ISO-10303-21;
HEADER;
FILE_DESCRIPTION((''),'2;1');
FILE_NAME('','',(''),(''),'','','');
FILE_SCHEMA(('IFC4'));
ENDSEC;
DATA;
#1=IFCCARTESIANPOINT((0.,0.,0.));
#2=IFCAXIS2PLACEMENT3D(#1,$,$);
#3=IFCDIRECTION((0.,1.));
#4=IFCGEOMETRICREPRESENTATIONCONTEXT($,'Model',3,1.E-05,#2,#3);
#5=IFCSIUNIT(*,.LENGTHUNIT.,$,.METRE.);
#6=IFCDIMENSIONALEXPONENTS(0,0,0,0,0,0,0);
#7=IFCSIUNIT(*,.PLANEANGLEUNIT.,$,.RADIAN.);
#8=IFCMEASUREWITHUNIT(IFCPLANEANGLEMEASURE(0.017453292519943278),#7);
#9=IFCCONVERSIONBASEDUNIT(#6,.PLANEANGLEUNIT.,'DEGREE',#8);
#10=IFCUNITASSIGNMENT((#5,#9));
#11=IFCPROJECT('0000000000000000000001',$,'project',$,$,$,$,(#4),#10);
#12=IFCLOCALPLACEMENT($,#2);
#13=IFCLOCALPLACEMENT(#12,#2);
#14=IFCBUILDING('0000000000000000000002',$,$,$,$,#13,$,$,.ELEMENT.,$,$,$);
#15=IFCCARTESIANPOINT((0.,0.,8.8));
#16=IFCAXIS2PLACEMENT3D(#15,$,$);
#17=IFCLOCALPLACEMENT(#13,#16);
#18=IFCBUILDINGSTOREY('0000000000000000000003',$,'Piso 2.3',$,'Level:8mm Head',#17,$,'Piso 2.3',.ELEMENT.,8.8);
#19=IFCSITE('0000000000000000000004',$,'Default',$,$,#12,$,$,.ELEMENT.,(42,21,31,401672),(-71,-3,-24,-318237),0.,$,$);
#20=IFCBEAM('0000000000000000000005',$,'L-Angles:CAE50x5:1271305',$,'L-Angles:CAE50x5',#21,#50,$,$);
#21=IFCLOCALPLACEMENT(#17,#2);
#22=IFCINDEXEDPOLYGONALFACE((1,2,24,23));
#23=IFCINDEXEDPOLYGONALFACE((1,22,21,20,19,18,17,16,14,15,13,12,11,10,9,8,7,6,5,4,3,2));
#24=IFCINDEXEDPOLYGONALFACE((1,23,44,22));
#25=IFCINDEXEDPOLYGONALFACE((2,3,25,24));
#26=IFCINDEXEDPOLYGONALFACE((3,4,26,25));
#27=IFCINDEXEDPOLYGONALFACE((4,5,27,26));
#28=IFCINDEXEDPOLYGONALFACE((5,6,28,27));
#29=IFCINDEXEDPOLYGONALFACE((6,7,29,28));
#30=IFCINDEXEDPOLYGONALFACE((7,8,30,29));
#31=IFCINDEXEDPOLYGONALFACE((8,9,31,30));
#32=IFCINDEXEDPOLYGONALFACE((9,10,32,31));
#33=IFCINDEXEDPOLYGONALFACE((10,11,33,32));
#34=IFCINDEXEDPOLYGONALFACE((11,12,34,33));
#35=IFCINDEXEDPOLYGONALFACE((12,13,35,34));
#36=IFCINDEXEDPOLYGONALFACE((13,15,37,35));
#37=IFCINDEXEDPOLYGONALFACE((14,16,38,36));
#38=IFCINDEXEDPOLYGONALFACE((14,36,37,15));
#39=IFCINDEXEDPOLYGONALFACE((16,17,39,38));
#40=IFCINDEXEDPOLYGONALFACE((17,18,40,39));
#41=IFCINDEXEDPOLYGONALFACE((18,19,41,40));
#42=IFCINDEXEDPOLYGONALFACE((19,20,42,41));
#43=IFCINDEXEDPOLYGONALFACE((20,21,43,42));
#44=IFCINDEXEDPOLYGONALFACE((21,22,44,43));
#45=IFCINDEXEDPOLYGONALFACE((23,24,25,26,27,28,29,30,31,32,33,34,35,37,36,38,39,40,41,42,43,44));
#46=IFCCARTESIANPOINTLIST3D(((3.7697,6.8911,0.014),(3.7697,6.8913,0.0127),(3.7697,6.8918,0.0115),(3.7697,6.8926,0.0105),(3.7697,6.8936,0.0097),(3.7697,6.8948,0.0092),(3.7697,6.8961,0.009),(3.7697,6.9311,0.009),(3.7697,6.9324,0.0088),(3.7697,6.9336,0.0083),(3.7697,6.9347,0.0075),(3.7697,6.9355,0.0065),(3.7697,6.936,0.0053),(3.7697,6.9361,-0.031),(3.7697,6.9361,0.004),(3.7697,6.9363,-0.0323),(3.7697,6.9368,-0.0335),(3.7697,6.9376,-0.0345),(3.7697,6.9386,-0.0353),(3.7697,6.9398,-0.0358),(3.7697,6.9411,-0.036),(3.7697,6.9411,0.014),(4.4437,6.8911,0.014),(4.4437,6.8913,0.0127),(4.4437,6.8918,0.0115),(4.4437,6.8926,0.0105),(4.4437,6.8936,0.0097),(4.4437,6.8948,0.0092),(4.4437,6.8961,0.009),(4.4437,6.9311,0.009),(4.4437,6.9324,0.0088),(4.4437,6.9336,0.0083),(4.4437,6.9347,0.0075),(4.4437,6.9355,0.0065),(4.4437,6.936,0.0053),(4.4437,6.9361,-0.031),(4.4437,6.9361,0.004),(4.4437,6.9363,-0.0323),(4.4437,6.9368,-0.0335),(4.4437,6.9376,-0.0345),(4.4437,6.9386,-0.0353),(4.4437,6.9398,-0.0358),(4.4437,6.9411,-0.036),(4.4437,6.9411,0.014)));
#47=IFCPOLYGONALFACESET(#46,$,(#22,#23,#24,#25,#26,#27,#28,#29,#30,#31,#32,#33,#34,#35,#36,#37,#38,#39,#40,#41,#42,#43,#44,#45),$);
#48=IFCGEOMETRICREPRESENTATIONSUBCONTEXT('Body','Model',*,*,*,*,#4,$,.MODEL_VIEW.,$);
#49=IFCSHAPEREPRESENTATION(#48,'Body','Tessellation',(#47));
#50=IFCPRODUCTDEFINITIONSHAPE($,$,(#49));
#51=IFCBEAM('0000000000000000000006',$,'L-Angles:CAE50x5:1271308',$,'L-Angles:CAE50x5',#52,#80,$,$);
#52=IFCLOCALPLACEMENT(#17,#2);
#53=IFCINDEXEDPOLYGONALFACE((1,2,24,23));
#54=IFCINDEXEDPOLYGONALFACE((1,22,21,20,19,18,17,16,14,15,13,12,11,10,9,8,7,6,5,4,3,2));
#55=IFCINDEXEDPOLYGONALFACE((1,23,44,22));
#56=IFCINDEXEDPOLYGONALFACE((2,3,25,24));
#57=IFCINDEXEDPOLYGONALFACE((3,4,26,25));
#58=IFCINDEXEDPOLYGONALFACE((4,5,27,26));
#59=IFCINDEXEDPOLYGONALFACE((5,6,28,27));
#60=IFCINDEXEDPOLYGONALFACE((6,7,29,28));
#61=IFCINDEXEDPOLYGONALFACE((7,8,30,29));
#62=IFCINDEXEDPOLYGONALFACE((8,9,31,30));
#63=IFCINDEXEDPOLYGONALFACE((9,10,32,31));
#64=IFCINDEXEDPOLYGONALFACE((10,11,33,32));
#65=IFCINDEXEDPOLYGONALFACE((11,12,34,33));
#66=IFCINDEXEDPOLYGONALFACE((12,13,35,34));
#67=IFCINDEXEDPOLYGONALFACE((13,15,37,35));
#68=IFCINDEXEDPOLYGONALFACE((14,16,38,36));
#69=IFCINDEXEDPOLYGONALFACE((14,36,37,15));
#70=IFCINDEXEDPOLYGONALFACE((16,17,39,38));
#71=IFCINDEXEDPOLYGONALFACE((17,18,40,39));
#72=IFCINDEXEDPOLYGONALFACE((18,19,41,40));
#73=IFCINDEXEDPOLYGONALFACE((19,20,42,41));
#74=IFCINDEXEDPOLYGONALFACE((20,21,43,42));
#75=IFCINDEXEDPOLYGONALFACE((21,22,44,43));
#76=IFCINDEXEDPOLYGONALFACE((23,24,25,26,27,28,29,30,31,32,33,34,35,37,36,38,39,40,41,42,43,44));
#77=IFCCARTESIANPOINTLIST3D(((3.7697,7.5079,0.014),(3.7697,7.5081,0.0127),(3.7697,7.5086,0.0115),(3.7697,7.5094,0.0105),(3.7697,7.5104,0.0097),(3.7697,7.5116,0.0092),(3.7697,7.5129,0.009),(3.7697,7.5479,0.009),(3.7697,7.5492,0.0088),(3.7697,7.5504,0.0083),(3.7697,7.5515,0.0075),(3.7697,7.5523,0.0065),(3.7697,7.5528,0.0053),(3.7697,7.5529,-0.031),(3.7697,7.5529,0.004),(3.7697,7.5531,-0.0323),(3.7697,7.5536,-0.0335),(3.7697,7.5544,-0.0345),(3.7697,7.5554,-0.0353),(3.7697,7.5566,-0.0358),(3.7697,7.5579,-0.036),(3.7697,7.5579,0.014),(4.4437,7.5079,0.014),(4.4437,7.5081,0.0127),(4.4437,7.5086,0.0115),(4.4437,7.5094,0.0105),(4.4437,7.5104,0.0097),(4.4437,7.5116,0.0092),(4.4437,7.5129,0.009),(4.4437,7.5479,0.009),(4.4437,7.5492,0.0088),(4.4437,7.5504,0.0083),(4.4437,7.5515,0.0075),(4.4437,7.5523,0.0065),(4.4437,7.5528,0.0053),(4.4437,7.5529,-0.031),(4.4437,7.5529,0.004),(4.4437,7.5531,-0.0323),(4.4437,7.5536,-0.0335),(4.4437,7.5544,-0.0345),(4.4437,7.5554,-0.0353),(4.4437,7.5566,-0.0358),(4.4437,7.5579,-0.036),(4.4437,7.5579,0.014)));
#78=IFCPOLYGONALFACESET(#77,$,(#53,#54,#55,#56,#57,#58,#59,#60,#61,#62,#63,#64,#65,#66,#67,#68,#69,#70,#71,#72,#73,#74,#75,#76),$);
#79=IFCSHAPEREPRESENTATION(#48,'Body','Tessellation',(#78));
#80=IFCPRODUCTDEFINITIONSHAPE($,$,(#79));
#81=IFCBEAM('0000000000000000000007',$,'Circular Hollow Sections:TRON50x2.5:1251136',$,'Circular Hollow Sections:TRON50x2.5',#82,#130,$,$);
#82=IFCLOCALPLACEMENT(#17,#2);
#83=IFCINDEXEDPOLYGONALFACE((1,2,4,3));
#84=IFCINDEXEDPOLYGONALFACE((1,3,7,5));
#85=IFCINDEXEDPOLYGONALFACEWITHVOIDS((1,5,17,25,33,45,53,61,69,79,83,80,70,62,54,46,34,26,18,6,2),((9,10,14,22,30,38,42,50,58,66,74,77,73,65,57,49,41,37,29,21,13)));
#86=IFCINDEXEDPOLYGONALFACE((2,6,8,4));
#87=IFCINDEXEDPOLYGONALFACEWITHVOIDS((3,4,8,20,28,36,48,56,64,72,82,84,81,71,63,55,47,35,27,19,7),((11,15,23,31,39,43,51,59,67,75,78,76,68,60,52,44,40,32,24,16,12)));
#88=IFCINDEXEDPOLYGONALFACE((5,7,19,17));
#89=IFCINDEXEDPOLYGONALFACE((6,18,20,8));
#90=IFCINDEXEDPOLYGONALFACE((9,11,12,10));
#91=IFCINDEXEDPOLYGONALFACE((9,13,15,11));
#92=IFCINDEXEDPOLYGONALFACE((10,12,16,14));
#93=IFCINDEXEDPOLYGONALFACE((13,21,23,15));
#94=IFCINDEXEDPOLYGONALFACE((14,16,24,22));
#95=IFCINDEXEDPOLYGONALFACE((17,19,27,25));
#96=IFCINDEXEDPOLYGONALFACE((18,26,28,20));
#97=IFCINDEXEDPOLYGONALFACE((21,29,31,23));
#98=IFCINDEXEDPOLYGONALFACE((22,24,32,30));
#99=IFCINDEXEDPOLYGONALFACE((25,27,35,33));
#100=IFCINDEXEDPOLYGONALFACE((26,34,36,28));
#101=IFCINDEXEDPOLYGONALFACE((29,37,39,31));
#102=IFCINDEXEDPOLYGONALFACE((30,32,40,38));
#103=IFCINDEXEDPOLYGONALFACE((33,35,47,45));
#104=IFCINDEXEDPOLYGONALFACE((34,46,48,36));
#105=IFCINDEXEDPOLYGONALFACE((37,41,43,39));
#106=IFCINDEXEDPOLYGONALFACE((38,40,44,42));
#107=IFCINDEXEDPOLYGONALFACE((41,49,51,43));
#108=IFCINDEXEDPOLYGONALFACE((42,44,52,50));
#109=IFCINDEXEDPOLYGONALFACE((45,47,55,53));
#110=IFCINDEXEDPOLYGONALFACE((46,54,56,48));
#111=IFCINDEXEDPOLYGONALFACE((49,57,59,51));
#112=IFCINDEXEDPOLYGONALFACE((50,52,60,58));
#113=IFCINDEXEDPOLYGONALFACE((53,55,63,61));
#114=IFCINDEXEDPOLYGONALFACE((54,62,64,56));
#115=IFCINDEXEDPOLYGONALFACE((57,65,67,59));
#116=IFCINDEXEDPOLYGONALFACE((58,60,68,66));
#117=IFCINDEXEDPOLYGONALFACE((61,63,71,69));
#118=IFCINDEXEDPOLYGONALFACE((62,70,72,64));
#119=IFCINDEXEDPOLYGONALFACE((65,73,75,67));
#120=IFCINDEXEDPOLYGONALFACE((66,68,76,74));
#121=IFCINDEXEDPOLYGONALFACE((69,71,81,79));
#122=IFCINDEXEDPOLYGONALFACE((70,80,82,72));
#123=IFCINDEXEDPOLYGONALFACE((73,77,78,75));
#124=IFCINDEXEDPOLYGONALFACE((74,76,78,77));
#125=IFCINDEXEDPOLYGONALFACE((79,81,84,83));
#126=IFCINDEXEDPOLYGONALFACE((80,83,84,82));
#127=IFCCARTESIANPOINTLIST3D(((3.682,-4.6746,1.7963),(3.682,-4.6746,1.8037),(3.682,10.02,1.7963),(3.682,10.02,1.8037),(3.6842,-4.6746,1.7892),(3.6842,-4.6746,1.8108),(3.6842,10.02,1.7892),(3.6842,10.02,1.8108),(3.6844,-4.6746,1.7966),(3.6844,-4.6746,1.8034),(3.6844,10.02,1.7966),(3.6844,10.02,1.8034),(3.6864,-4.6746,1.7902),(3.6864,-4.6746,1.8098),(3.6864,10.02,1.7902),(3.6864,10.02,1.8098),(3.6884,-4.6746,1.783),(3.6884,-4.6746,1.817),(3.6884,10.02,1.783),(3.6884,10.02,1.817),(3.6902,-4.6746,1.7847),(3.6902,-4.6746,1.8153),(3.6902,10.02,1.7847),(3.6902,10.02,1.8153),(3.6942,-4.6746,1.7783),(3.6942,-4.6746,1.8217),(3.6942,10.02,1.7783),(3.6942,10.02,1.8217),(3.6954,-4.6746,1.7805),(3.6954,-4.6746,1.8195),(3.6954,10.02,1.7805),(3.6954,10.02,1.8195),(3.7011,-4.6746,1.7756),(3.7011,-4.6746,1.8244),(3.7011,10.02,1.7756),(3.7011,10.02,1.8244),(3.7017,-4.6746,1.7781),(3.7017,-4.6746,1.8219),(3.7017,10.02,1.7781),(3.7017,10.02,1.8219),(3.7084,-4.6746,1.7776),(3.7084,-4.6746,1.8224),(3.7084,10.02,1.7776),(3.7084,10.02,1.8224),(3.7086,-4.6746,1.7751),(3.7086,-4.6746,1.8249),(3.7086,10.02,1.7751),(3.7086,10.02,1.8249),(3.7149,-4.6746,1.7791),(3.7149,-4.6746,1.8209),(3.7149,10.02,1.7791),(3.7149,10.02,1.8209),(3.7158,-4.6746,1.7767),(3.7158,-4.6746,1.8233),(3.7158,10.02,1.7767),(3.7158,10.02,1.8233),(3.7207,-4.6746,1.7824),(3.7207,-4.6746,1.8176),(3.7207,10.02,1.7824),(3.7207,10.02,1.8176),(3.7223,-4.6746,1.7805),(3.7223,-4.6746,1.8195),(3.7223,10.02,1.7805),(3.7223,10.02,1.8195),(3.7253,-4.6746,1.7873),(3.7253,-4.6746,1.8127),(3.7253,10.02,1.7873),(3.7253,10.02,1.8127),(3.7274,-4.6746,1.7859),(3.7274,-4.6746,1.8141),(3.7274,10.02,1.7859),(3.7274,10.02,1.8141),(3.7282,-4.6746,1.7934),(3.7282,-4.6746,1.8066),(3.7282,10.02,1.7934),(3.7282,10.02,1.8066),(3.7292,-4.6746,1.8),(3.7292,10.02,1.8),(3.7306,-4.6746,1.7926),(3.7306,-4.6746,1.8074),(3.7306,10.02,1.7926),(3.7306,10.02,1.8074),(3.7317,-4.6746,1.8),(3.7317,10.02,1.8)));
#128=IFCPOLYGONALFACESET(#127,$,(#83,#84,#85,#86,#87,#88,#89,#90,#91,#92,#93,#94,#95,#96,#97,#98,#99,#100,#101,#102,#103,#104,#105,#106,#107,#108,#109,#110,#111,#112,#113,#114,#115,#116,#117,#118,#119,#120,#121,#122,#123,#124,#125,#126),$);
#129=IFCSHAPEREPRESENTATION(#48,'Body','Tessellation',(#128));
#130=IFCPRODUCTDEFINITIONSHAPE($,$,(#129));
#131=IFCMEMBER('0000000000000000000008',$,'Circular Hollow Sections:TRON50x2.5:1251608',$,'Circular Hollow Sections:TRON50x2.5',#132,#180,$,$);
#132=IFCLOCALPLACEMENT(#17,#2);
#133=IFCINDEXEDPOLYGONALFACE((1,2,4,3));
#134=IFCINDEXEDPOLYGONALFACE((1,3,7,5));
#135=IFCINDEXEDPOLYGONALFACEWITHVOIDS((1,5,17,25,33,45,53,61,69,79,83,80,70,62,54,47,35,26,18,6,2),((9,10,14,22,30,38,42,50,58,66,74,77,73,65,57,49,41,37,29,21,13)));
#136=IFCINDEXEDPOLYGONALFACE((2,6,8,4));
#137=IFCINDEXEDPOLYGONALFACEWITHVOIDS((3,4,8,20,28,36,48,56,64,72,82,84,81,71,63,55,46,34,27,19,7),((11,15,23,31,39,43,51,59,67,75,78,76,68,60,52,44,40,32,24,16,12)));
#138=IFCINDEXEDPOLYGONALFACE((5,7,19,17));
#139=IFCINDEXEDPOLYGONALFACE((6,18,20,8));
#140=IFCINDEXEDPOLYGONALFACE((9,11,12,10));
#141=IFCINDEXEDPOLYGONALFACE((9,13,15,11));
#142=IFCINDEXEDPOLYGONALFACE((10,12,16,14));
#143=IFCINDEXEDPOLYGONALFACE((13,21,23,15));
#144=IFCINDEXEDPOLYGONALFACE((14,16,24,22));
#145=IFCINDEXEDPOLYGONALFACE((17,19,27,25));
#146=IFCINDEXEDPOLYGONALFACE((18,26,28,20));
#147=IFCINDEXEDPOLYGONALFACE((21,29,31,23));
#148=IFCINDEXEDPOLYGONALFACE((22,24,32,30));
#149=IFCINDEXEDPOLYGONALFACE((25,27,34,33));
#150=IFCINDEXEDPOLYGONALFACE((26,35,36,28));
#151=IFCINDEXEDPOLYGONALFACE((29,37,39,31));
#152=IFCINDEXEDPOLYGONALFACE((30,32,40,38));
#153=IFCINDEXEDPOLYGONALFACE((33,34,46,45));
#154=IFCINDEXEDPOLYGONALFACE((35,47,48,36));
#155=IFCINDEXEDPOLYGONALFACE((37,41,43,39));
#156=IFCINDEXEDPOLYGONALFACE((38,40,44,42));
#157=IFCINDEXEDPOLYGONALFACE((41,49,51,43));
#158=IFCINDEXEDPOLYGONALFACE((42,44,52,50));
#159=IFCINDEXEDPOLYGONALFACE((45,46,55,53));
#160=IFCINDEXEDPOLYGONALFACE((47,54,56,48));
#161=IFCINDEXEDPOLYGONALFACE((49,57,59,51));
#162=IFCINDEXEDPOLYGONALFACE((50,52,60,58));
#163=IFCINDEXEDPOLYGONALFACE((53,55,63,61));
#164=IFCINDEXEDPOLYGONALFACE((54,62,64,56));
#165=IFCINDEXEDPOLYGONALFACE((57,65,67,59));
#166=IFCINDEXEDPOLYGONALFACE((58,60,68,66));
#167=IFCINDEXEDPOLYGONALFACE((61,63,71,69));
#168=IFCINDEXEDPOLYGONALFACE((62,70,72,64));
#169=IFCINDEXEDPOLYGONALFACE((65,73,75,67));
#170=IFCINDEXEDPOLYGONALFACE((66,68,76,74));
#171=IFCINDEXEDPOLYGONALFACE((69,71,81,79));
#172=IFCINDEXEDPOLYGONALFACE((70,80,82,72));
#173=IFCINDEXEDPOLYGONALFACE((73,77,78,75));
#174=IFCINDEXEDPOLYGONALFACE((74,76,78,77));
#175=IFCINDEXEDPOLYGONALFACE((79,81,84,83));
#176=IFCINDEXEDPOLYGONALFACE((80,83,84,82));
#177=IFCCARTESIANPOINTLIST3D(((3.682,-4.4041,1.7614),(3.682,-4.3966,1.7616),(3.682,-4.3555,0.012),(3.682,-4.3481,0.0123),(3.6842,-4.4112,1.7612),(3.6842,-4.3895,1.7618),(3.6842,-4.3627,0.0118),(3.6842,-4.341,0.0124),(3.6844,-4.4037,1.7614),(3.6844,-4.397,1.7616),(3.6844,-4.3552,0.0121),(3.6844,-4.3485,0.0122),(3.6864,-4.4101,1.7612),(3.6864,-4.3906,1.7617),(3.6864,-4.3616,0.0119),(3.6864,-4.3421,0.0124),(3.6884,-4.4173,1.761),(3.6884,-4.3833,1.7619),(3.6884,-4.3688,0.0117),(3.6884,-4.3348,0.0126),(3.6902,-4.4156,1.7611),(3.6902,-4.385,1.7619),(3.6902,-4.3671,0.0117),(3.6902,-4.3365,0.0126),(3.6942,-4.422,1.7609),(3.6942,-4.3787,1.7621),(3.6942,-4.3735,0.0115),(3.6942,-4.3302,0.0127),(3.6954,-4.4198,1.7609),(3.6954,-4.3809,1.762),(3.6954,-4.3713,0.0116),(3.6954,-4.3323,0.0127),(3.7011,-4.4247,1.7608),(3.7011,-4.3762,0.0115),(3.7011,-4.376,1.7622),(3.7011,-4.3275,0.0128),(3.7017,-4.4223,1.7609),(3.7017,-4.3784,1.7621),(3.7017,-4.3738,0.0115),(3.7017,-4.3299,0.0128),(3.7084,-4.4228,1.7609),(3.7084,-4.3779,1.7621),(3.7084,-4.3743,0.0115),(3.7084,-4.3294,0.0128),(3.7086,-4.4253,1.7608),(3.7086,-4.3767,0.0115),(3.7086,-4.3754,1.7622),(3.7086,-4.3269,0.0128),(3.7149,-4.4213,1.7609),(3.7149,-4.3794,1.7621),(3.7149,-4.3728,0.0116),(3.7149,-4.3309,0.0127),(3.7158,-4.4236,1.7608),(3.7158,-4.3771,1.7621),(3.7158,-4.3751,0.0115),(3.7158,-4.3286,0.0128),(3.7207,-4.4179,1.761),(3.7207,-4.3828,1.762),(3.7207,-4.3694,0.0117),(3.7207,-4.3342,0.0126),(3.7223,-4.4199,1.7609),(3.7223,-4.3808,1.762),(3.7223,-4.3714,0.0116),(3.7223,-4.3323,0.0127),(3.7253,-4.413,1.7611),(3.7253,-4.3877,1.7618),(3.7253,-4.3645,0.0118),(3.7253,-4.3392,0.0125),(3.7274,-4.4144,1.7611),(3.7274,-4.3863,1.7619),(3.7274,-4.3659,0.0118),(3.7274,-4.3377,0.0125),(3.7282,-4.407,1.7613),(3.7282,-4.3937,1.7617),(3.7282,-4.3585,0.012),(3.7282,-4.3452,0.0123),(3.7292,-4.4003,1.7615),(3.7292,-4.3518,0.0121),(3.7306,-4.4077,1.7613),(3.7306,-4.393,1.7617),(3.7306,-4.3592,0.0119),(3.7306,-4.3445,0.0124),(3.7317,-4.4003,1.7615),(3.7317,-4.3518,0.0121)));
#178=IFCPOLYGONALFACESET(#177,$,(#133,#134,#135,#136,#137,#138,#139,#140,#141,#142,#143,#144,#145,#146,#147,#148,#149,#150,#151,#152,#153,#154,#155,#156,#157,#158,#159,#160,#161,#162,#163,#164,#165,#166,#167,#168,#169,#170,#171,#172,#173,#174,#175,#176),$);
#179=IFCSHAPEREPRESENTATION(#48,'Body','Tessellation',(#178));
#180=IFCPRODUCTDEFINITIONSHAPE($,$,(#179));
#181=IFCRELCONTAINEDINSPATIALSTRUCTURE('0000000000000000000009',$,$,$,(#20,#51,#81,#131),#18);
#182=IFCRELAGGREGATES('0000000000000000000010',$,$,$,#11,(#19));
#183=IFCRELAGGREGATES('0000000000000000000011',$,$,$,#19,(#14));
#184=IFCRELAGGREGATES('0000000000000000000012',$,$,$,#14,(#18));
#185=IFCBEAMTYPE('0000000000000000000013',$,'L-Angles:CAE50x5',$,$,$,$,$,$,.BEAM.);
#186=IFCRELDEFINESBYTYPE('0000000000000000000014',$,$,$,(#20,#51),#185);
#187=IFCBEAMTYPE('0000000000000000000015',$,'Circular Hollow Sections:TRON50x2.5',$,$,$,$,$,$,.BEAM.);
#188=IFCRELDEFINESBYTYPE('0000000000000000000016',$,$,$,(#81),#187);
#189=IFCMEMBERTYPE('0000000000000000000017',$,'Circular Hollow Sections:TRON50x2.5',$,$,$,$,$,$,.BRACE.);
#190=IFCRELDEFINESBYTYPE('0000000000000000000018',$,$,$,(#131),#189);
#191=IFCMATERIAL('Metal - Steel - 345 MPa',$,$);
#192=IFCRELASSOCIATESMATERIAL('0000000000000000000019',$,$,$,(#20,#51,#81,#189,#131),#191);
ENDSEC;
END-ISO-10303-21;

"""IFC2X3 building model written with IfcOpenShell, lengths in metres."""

from ifc_helpers import new_model, entity, si_unit, converted_unit, direction, frame, frame_2d, origin, origin_2d_with_axis, place, context, subcontext, project, spatial, polyline, circle_curve, parameter, trimmed, segment, composite_curve, hollow_circle, outline, extrude, source, transform, mapped, material, type_object, type_shapes, element, save


model = new_model("IFC2X3")

# Units and contexts
model_context = context("Model", 3, precision=1e-05, world=origin(), true_north=direction((0.0, 1.0)))
body_context = subcontext(model_context, "Body", "Model", "MODEL_VIEW")
ifc_project = project(units=[si_unit("LENGTHUNIT", "METRE"), converted_unit("PLANEANGLEUNIT", "DEGREE", entity("IfcPlaneAngleMeasure", 0.017453292519943278), si_unit("PLANEANGLEUNIT", "RADIAN"), dimensions=[0, 0, 0, 0, 0, 0, 0])], contexts=[model_context])

# Site, building, storey
site_placement = place(None, origin())
site = spatial("IfcSite", under=ifc_project, at=site_placement, Name="Default", CompositionType="ELEMENT", RefLatitude=(42, 21, 31, 401672), RefLongitude=(-71, -3, -24, -318237), RefElevation=0.0)
building_placement = place(site_placement, origin())
building = spatial("IfcBuilding", under=site, at=building_placement, CompositionType="ELEMENT")
storey_placement = place(building_placement, frame((0.0, 0.0, 8.8)))
storey = spatial("IfcBuildingStorey", under=building, at=storey_placement, Name="Piso 2.3", ObjectType="Level:8mm Head", LongName="Piso 2.3", CompositionType="ELEMENT", Elevation=8.8)

# Beams
ifc_material_1 = material(Name="Metal - Steel - 345 MPa")
beam_type_1 = type_object("IfcBeamType", Name="L-Angles:CAE50x5", PredefinedType="BEAM")
beam_1_placement = place(storey_placement, frame((3.7067, 6.9271, 0.0)))
element("IfcBeam", 1, at=beam_1_placement, inside=storey, type_object=beam_type_1, material=ifc_material_1, Name="L-Angles:CAE50x5:1271305", ObjectType="L-Angles:CAE50x5", context=body_context, shape_type="SweptSolid", body=[
    extrude(outline(composite_curve([segment(polyline([(-0.0336, -0.0164), (0.0164, -0.0164)]), True, "CONTINUOUS"), segment(polyline([(0.0164, -0.0164), (0.0164, 0.0336)]), True, "CONTINUOUS"), segment(trimmed(circle_curve(frame_2d((0.0164, 0.0286), x_axis=(0.0, 1.0)), 0.005), [parameter(0.0)], [parameter(90.0)], True, "PARAMETER"), True, "CONTINUOUS"), segment(polyline([(0.0114, 0.0286), (0.0114, -0.0064)]), True, "CONTINUOUS"), segment(trimmed(circle_curve(frame_2d((0.0064, -0.0064), x_axis=(1.0, 0.0)), 0.005), [parameter(270.0)], [parameter(0.0)], True, "PARAMETER"), False, "CONTINUOUS"), segment(polyline([(0.0064, -0.0114), (-0.0286, -0.0114)]), True, "CONTINUOUS"), segment(trimmed(circle_curve(frame_2d((-0.0286, -0.0164), x_axis=(0.0, 1.0)), 0.005), [parameter(0.0)], [parameter(90.0)], True, "PARAMETER"), True, "CONTINUOUS")], self_intersect=False)), frame((0.063, -0.0024, -0.0024), z_axis=(1.0, 0.0, 0.0), x_axis=(0.0, 0.0, 1.0)), (0.0, 0.0, 1.0), 0.674),
])
beam_2_placement = place(storey_placement, frame((3.7067, 7.5439, 0.0)))
element("IfcBeam", 2, at=beam_2_placement, inside=storey, type_object=beam_type_1, material=ifc_material_1, Name="L-Angles:CAE50x5:1271308", ObjectType="L-Angles:CAE50x5", context=body_context, shape_type="SweptSolid", body=[
    extrude(outline(composite_curve([segment(polyline([(-0.0336, -0.0164), (0.0164, -0.0164)]), True, "CONTINUOUS"), segment(polyline([(0.0164, -0.0164), (0.0164, 0.0336)]), True, "CONTINUOUS"), segment(trimmed(circle_curve(frame_2d((0.0164, 0.0286), x_axis=(0.0, 1.0)), 0.005), [parameter(0.0)], [parameter(90.0)], True, "PARAMETER"), True, "CONTINUOUS"), segment(polyline([(0.0114, 0.0286), (0.0114, -0.0064)]), True, "CONTINUOUS"), segment(trimmed(circle_curve(frame_2d((0.0064, -0.0064), x_axis=(1.0, 0.0)), 0.005), [parameter(270.0)], [parameter(0.0)], True, "PARAMETER"), False, "CONTINUOUS"), segment(polyline([(0.0064, -0.0114), (-0.0286, -0.0114)]), True, "CONTINUOUS"), segment(trimmed(circle_curve(frame_2d((-0.0286, -0.0164), x_axis=(0.0, 1.0)), 0.005), [parameter(0.0)], [parameter(90.0)], True, "PARAMETER"), True, "CONTINUOUS")], self_intersect=False)), frame((0.063, -0.0024, -0.0024), z_axis=(1.0, 0.0, 0.0), x_axis=(0.0, 0.0, 1.0)), (0.0, 0.0, 1.0), 0.674),
])
beam_type_2 = type_object("IfcBeamType", Name="Circular Hollow Sections:TRON50x2.5", PredefinedType="BEAM")
beam_3_placement = place(storey_placement, frame((3.6801, -4.6746, 1.774), z_axis=(0.0, 0.0, 1.0), x_axis=(0.0, -1.0, 0.0)))
element("IfcBeam", 3, at=beam_3_placement, inside=storey, type_object=beam_type_2, material=ifc_material_1, Name="Circular Hollow Sections:TRON50x2.5:1251136", ObjectType="Circular Hollow Sections:TRON50x2.5", context=body_context, shape_type="SweptSolid", body=[
    extrude(hollow_circle(Radius=0.025, WallThickness=0.0025, at=origin_2d_with_axis()), frame((-14.6946, 0.0266, 0.026), z_axis=(1.0, 0.0, 0.0), x_axis=(0.0, 1.0, 0.0)), (0.0, 0.0, 1.0), 14.6946),
])

# Member
member_type_1 = type_object("IfcMemberType", Name="Circular Hollow Sections:TRON50x2.5", PredefinedType="BRACE", material=ifc_material_1)
shared_shape_1 = source(origin(), body_context, "Body", "SweptSolid", [
    extrude(hollow_circle(Radius=0.025, WallThickness=0.0025, at=frame_2d((0.0, 0.0), x_axis=(1.0, 0.0))), frame((-0.8875, 0.0, 0.0), z_axis=(1.0, 0.0, 0.0), x_axis=(0.0, 1.0, 0.0)), (0.0, 0.0, 1.0), 1.75),
])
type_shapes(member_type_1, [shared_shape_1])
member_placement = place(storey_placement, frame((3.7067, -4.3764, 0.8993), z_axis=(0.0, 0.999616, 0.027721), x_axis=(0.0, -0.027721, 0.999616)))
element("IfcMember", 4, at=member_placement, inside=storey, type_object=member_type_1, material=ifc_material_1, Name="Circular Hollow Sections:TRON50x2.5:1251608", ObjectType="Circular Hollow Sections:TRON50x2.5", context=body_context, shape_type="MappedRepresentation", body=[
    mapped(shared_shape_1, transform((0.0, 0.0, 0.0), scale=1.0)),
])

save(model, "model.ifc")
